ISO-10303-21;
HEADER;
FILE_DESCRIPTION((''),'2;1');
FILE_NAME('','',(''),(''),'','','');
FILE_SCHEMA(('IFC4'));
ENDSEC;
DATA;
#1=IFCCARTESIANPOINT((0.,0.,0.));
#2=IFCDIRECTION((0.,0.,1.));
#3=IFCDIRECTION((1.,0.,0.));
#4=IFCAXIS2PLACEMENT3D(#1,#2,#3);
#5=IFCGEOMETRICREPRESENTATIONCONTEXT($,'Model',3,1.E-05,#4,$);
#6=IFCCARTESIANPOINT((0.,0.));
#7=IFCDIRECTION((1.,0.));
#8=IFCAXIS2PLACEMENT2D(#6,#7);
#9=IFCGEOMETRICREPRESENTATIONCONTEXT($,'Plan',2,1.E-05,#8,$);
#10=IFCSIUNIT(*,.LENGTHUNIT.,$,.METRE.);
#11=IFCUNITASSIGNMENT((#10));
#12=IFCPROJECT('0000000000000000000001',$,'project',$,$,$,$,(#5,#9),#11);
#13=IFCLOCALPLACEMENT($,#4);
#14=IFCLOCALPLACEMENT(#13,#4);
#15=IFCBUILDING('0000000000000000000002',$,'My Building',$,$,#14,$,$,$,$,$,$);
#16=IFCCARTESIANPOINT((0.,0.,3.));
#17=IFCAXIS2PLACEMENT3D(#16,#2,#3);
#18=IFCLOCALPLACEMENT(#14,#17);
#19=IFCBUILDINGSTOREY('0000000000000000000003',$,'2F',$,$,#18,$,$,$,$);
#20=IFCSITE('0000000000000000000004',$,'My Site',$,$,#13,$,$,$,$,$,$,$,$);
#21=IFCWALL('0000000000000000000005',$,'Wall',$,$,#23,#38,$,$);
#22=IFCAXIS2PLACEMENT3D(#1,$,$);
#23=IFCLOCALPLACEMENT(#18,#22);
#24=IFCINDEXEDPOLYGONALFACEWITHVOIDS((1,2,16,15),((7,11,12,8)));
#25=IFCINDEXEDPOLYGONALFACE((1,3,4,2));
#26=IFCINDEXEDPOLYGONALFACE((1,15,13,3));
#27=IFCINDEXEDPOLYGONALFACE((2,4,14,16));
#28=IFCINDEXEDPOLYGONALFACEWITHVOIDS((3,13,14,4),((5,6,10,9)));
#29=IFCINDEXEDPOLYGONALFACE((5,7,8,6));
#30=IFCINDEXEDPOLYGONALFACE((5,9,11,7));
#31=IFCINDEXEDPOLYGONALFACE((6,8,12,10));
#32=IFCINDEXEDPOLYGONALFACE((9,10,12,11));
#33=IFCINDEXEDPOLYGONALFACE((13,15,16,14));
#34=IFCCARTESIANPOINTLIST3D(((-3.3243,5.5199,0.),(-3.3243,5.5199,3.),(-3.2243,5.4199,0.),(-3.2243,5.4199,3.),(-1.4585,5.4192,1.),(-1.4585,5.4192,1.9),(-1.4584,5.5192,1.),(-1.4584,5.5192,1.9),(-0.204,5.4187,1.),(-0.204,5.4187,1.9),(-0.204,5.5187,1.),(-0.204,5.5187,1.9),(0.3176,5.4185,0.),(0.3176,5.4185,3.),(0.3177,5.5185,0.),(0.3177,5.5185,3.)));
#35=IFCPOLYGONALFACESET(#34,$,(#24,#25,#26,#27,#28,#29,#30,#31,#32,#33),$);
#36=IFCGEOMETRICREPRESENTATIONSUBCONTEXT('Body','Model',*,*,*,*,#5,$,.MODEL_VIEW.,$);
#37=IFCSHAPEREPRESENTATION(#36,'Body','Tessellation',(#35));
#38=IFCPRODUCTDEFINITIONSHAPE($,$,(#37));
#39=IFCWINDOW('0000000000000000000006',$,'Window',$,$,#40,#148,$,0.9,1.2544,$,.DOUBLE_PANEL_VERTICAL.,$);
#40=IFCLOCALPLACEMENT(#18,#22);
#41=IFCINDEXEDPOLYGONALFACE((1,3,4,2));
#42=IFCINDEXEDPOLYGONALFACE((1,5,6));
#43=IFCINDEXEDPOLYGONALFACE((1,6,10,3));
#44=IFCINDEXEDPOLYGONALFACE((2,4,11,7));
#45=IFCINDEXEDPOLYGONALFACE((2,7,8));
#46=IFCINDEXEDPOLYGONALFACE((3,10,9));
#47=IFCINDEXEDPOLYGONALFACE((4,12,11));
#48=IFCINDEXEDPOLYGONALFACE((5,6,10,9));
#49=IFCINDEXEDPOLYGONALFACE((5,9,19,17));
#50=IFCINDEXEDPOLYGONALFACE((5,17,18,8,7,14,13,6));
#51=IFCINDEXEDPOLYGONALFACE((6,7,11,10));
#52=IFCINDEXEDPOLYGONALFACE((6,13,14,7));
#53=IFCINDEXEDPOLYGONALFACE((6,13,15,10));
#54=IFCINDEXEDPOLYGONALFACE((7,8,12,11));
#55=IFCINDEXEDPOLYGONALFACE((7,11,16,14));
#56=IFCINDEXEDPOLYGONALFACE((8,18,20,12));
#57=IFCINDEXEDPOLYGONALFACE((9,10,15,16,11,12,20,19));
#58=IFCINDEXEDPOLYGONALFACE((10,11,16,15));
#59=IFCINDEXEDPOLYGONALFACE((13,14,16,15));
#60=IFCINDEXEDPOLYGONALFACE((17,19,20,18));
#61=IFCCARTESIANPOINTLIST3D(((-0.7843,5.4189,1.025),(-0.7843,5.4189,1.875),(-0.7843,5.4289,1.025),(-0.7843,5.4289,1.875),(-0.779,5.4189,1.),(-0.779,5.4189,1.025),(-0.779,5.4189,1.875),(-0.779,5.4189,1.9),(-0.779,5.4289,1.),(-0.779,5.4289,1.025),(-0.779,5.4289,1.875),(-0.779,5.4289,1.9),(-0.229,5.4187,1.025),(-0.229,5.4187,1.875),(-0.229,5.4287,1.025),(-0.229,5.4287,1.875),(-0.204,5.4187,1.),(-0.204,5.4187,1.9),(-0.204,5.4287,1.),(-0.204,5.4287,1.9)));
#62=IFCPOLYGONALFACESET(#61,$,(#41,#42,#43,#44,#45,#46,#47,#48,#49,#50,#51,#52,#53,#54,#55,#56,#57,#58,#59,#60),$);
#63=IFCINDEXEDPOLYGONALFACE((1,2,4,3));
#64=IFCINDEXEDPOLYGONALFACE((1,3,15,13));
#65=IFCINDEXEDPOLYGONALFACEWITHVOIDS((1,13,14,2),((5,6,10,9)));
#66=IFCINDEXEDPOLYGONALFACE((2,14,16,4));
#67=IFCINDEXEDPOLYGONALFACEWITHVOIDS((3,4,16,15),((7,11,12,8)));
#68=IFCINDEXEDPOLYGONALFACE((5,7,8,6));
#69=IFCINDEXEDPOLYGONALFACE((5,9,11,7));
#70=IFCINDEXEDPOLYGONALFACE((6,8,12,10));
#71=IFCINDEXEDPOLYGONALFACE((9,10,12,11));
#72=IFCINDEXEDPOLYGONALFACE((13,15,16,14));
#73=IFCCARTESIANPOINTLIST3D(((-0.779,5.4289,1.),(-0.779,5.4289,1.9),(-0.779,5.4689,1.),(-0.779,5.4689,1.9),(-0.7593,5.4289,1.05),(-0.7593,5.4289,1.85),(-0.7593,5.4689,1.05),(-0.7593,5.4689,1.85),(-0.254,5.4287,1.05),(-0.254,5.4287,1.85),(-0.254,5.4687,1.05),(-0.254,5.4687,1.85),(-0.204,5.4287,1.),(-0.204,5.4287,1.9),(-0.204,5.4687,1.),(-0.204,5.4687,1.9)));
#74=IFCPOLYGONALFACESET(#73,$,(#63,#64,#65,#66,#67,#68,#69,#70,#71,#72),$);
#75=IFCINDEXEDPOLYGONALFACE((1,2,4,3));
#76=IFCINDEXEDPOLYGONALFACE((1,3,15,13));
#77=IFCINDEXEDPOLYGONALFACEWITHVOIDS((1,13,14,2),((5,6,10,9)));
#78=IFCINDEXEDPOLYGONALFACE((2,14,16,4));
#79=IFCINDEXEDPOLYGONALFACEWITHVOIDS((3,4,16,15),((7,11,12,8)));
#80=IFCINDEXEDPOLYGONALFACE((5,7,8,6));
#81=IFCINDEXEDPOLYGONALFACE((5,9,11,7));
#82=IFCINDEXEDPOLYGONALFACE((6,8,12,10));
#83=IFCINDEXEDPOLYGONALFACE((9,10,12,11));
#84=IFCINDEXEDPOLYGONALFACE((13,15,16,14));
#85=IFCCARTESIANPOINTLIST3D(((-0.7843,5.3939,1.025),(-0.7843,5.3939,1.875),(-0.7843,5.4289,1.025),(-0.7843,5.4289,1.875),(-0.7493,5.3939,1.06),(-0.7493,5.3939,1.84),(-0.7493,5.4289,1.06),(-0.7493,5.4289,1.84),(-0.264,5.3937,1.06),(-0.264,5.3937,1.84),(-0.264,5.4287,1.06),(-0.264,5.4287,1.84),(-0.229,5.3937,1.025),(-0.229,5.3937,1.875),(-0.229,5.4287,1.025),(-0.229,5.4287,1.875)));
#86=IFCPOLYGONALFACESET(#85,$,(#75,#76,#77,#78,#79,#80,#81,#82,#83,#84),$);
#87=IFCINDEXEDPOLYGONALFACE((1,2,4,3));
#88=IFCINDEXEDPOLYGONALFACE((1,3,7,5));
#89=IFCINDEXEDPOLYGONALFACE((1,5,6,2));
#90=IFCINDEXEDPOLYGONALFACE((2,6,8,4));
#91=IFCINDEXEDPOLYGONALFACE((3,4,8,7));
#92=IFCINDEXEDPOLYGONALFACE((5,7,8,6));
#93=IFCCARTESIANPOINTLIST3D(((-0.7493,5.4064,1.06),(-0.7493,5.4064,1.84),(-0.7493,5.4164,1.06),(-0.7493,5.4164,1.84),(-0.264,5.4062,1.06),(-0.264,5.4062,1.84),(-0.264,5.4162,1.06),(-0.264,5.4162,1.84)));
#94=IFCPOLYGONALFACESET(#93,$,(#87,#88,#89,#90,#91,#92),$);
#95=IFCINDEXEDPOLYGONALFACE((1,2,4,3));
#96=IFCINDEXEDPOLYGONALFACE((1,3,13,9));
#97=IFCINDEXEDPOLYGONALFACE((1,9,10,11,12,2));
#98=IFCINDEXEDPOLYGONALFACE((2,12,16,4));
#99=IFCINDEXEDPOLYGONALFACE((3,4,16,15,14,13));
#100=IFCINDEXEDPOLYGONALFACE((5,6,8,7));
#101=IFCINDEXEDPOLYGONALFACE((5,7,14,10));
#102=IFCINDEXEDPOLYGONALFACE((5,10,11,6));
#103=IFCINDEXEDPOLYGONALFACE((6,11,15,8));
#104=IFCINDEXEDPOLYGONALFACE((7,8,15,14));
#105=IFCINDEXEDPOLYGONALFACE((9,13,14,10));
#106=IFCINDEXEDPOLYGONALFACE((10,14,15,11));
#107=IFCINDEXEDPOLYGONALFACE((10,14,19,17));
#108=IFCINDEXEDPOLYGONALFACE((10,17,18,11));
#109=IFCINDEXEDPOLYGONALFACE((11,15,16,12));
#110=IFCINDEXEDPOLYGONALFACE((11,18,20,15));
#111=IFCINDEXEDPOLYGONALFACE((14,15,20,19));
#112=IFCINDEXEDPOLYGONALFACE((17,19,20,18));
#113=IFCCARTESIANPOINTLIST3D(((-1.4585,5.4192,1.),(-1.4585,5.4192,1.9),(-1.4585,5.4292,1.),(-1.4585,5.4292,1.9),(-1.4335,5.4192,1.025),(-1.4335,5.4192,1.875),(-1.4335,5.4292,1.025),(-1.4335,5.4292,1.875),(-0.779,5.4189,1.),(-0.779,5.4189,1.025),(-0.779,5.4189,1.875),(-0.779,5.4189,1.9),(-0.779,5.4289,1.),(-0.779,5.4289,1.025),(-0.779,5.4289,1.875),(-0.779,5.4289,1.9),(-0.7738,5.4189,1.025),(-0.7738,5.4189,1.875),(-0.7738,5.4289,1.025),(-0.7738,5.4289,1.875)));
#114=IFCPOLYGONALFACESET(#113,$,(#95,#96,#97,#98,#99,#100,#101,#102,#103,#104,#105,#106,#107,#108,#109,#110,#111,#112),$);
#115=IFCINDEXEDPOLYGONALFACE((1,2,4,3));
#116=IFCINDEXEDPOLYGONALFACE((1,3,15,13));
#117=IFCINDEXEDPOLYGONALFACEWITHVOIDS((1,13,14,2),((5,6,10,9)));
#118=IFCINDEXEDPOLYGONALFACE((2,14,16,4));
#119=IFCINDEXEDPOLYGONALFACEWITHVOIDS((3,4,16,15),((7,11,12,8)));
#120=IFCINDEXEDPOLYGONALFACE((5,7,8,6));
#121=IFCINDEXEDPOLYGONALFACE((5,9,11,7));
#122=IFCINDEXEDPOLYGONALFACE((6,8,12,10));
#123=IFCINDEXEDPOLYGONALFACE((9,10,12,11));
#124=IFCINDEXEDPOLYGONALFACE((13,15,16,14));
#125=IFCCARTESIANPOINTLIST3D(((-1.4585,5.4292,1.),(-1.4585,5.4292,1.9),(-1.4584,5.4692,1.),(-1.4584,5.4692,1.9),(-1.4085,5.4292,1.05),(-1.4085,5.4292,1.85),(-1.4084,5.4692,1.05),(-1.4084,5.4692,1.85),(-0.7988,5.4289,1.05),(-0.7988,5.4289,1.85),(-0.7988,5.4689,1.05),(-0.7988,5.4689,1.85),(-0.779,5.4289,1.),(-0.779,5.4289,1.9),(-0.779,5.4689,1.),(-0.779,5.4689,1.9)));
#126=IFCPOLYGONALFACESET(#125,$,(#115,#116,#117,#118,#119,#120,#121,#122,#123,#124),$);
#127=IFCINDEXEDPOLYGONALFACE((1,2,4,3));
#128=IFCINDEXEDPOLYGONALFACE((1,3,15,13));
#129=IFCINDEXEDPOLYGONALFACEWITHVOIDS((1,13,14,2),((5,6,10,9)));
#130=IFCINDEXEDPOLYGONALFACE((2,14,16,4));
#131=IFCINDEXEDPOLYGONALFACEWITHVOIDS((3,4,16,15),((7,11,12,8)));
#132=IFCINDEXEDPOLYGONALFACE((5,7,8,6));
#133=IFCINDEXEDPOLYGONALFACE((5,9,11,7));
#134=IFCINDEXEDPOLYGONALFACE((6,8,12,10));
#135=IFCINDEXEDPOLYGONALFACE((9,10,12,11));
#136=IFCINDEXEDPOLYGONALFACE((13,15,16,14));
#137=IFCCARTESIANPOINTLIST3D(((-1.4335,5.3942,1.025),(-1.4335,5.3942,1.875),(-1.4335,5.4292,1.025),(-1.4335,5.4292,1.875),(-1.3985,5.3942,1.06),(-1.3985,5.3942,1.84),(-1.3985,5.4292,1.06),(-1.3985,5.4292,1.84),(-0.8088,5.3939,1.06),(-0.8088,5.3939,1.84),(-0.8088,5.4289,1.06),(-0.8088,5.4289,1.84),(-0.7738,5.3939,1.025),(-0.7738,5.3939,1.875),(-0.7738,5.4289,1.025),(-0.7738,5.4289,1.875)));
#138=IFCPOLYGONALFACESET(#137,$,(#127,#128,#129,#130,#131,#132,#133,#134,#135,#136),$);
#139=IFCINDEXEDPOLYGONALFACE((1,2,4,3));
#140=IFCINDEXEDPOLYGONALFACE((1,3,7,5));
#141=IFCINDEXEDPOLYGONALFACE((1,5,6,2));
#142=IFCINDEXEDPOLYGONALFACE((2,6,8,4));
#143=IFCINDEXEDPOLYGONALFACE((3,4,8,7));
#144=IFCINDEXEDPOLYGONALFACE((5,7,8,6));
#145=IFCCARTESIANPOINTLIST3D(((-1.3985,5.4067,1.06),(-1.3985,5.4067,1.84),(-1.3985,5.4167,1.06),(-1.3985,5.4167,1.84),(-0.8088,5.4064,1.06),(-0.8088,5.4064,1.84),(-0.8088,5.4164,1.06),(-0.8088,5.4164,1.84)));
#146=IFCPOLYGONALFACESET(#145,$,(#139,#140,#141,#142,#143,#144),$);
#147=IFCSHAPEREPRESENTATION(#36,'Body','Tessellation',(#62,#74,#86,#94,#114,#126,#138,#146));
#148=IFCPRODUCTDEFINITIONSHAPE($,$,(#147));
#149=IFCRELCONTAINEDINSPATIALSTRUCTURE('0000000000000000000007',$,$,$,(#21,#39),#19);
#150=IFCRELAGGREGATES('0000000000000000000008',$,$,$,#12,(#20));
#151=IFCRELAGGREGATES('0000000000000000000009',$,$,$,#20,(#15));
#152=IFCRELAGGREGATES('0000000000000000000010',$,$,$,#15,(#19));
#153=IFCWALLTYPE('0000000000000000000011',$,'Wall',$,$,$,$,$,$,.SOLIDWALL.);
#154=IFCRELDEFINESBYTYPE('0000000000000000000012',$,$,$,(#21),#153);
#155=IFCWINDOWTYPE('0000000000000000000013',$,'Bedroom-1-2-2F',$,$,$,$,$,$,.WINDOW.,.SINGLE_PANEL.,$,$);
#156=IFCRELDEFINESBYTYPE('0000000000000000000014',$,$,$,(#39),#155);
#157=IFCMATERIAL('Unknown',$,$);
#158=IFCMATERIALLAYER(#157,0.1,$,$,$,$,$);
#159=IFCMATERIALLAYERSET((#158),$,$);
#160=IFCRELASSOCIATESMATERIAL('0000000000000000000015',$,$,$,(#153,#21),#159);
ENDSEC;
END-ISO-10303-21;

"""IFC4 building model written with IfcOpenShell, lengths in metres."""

from ifc_helpers import new_model, entity, si_unit, frame, origin_with_axes, origin_2d_with_axis, place, context, subcontext, project, spatial, line, indexed_curve, outline, extrude, shape, source, transform, mapped, material, layer, layer_set, layer_usage, type_object, type_shapes, element, fill, save


model = new_model("IFC4")

# Units and contexts
model_context = context("Model", 3, precision=1e-05, world=origin_with_axes())
plan_context = context("Plan", 2, precision=1e-05, world=origin_2d_with_axis())
body_context_1 = subcontext(model_context, "Body", "Model", "MODEL_VIEW")
body_context_2 = subcontext(plan_context, "Body", "Plan", "PLAN_VIEW")
ifc_project = project(units=[si_unit("LENGTHUNIT", "METRE")], contexts=[model_context, plan_context])

# Site, building, storey
site_placement = place(None, origin_with_axes())
site = spatial("IfcSite", under=ifc_project, at=site_placement, Name="My Site")
building_placement = place(site_placement, origin_with_axes())
building = spatial("IfcBuilding", under=site, at=building_placement, Name="My Building")
storey_placement = place(building_placement, frame((0.0, 0.0, 3.0), z_axis=(0.0, 0.0, 1.0), x_axis=(1.0, 0.0, 0.0)))
storey = spatial("IfcBuildingStorey", under=building, at=storey_placement, Name="2F")

# Shared definitions
ifc_material = material(Name="Unknown")

# Shared definitions
ifc_layer = layer(ifc_material, 0.1)
ifc_layer_set = layer_set([ifc_layer])
wall_type = type_object("IfcWallType", Name="Wall", PredefinedType="SOLIDWALL", material=ifc_layer_set)

# Wall, opening, window
ifc_layer_usage_1 = layer_usage(ifc_layer_set, "AXIS2", "POSITIVE", 0.0)
wall_1_placement = place(storey_placement, frame((-3.3243, 5.4199, 0.0), z_axis=(0.0, 0.0, 1.0), x_axis=(1.0, -0.000383, 0.0)))
wall_1 = element("IfcWall", 1, at=wall_1_placement, inside=storey, type_object=wall_type, material=ifc_layer_usage_1, Name="Wall", context=body_context_1, shape_type="SweptSolid", body=[
    extrude(outline(indexed_curve([(0.1, 0.0), (0.0, 0.1), (3.6419, 0.1), (3.6419, 0.0)], segments=[line(1, 2, 3, 4, 1)])), origin_with_axes(), (0.0, 0.0, 1.0), 3.0),
])
shared_shape_1 = source(origin_with_axes(), body_context_1, "Body", "SweptSolid", [
    extrude(outline(indexed_curve([(0.0, 0.0), (1.2544, 0.0), (1.2544, 0.9), (0.0, 0.9)], segments=[line(1, 2, 3, 4, 1)])), frame((0.0, -0.6, 0.0), z_axis=(0.0, -1.0, 0.0), x_axis=(1.0, 0.0, 0.0)), (0.0, 0.0, -1.0), 1.2),
])
opening_1_placement = place(wall_1_placement, frame((3.1202, 0.1, 1.0), z_axis=(0.0, 0.0, 1.0), x_axis=(-1.0, 0.0, 0.0)))
opening_1 = element("IfcOpeningElement", 2, at=opening_1_placement, cuts=wall_1, PredefinedType="OPENING", context=body_context_1, shape_type="MappedRepresentation", body=[
    mapped(shared_shape_1, transform((0.0, 0.0, 0.0), x_axis=(1.0, 0.0, 0.0), y_axis=(0.0, 1.0, 0.0), z_axis=(0.0, 0.0, 1.0), scale=1.0)),
])
window_type_1 = type_object("IfcWindowType", Name="Bedroom-1-2-2F", PartitioningType="SINGLE_PANEL", PredefinedType="WINDOW")
shared_shape_2 = source(origin_with_axes(), body_context_1, "Body", "SweptSolid", [
    extrude(outline(indexed_curve([(0.0, 0.0), (0.575, 0.0), (0.575, 0.9), (0.0, 0.9)], segments=[line(1, 2, 3, 4, 1)]), holes=[indexed_curve([(0.025, 0.025), (0.5803, 0.025), (0.5803, 0.875), (0.025, 0.875)], segments=[line(1, 2, 3, 4, 1)])]), frame((0.0, 0.09, 0.0), z_axis=(0.0, -1.0, 0.0), x_axis=(1.0, 0.0, 0.0)), (0.0, 0.0, -1.0), 0.01),
    extrude(outline(indexed_curve([(0.0, 0.0), (0.575, 0.0), (0.575, 0.9), (0.0, 0.9)], segments=[line(1, 2, 3, 4, 1)]), holes=[indexed_curve([(0.05, 0.05), (0.5553, 0.05), (0.5553, 0.85), (0.05, 0.85)], segments=[line(1, 2, 3, 4, 1)])]), frame((0.0, 0.05, 0.0), z_axis=(0.0, -1.0, 0.0), x_axis=(1.0, 0.0, 0.0)), (0.0, 0.0, -1.0), 0.04),
    extrude(outline(indexed_curve([(0.0, 0.0), (0.5553, 0.0), (0.5553, 0.85), (0.0, 0.85)], segments=[line(1, 2, 3, 4, 1)]), holes=[indexed_curve([(0.035, 0.035), (0.5203, 0.035), (0.5203, 0.815), (0.035, 0.815)], segments=[line(1, 2, 3, 4, 1)])]), frame((0.025, 0.09, 0.025), z_axis=(0.0, -1.0, 0.0), x_axis=(1.0, 0.0, 0.0)), (0.0, 0.0, -1.0), 0.035),
    extrude(outline(indexed_curve([(0.035, 0.035), (0.5203, 0.035), (0.5203, 0.815), (0.035, 0.815)], segments=[line(1, 2, 3, 4, 1)])), frame((0.025, 0.1025, 0.025), z_axis=(0.0, -1.0, 0.0), x_axis=(1.0, 0.0, 0.0)), (0.0, 0.0, -1.0), 0.01),
    extrude(outline(indexed_curve([(0.0, 0.0), (0.6794, 0.0), (0.6794, 0.9), (0.0, 0.9)], segments=[line(1, 2, 3, 4, 1)]), holes=[indexed_curve([(-0.0052, 0.025), (0.6544, 0.025), (0.6544, 0.875), (-0.0052, 0.875)], segments=[line(1, 2, 3, 4, 1)])]), frame((0.575, 0.09, 0.0), z_axis=(0.0, -1.0, 0.0), x_axis=(1.0, 0.0, 0.0)), (0.0, 0.0, -1.0), 0.01),
    extrude(outline(indexed_curve([(0.0, 0.0), (0.6794, 0.0), (0.6794, 0.9), (0.0, 0.9)], segments=[line(1, 2, 3, 4, 1)]), holes=[indexed_curve([(0.0198, 0.05), (0.6294, 0.05), (0.6294, 0.85), (0.0198, 0.85)], segments=[line(1, 2, 3, 4, 1)])]), frame((0.575, 0.05, 0.0), z_axis=(0.0, -1.0, 0.0), x_axis=(1.0, 0.0, 0.0)), (0.0, 0.0, -1.0), 0.04),
    extrude(outline(indexed_curve([(0.0, 0.0), (0.6596, 0.0), (0.6596, 0.85), (0.0, 0.85)], segments=[line(1, 2, 3, 4, 1)]), holes=[indexed_curve([(0.035, 0.035), (0.6246, 0.035), (0.6246, 0.815), (0.035, 0.815)], segments=[line(1, 2, 3, 4, 1)])]), frame((0.5698, 0.09, 0.025), z_axis=(0.0, -1.0, 0.0), x_axis=(1.0, 0.0, 0.0)), (0.0, 0.0, -1.0), 0.035),
    extrude(outline(indexed_curve([(0.035, 0.035), (0.6246, 0.035), (0.6246, 0.815), (0.035, 0.815)], segments=[line(1, 2, 3, 4, 1)])), frame((0.5698, 0.1025, 0.025), z_axis=(0.0, -1.0, 0.0), x_axis=(1.0, 0.0, 0.0)), (0.0, 0.0, -1.0), 0.01),
])
shared_shape_3 = source(origin_with_axes(), body_context_2, "Body", "Curve2D", [
    entity("IfcIndexedPolyCurve", entity("IfcCartesianPointList2D", [[0.05, 0.05], [0.5553, 0.05]])),
    entity("IfcIndexedPolyCurve", entity("IfcCartesianPointList2D", [[0.0, 0.1], [0.025, 0.1], [0.025, 0.09], [0.05, 0.09], [0.05, 0.05], [0.0, 0.05]]), [entity("IfcLineIndex", [1, 2, 3, 4, 5, 6, 1])]),
    entity("IfcIndexedPolyCurve", entity("IfcCartesianPointList2D", [[0.575, 0.1], [0.5803, 0.1], [0.5803, 0.09], [0.5553, 0.09], [0.5553, 0.05], [0.575, 0.05]])),
    entity("IfcIndexedPolyCurve", entity("IfcCartesianPointList2D", [[0.025, 0.09], [0.06, 0.09], [0.06, 0.125], [0.025, 0.125]]), [entity("IfcLineIndex", [1, 2, 3, 4, 1])]),
    entity("IfcIndexedPolyCurve", entity("IfcCartesianPointList2D", [[0.5803, 0.09], [0.5453, 0.09], [0.5453, 0.125], [0.5803, 0.125]]), [entity("IfcLineIndex", [1, 2, 3, 4, 1])]),
    entity("IfcIndexedPolyCurve", entity("IfcCartesianPointList2D", [[0.06, 0.09], [0.5453, 0.09]])),
    entity("IfcIndexedPolyCurve", entity("IfcCartesianPointList2D", [[0.06, 0.125], [0.5453, 0.125]])),
    entity("IfcIndexedPolyCurve", entity("IfcCartesianPointList2D", [[0.06, 0.1075], [0.5453, 0.1075]])),
    entity("IfcIndexedPolyCurve", entity("IfcCartesianPointList2D", [[0.5948, 0.05], [1.2044, 0.05]])),
    entity("IfcIndexedPolyCurve", entity("IfcCartesianPointList2D", [[0.575, 0.1], [0.5698, 0.1], [0.5698, 0.09], [0.5948, 0.09], [0.5948, 0.05], [0.575, 0.05]])),
    entity("IfcIndexedPolyCurve", entity("IfcCartesianPointList2D", [[1.2544, 0.1], [1.2294, 0.1], [1.2294, 0.09], [1.2044, 0.09], [1.2044, 0.05], [1.2544, 0.05]]), [entity("IfcLineIndex", [1, 2, 3, 4, 5, 6, 1])]),
    entity("IfcIndexedPolyCurve", entity("IfcCartesianPointList2D", [[0.5698, 0.09], [0.6048, 0.09], [0.6048, 0.125], [0.5698, 0.125]]), [entity("IfcLineIndex", [1, 2, 3, 4, 1])]),
    entity("IfcIndexedPolyCurve", entity("IfcCartesianPointList2D", [[1.2294, 0.09], [1.1944, 0.09], [1.1944, 0.125], [1.2294, 0.125]]), [entity("IfcLineIndex", [1, 2, 3, 4, 1])]),
    entity("IfcIndexedPolyCurve", entity("IfcCartesianPointList2D", [[0.6048, 0.09], [1.1944, 0.09]])),
    entity("IfcIndexedPolyCurve", entity("IfcCartesianPointList2D", [[0.6048, 0.125], [1.1944, 0.125]])),
    entity("IfcIndexedPolyCurve", entity("IfcCartesianPointList2D", [[0.6048, 0.1075], [1.1944, 0.1075]])),
])
type_shapes(window_type_1, [shared_shape_2, shared_shape_3])
window_1_placement = place(opening_1_placement, origin_with_axes())
window_1 = element("IfcWindow", 3, at=window_1_placement, inside=storey, type_object=window_type_1, Name="Window", OverallHeight=0.9, OverallWidth=1.2544, PartitioningType="DOUBLE_PANEL_VERTICAL", shapes=[
    shape(body_context_1, "Body", "MappedRepresentation", [mapped(shared_shape_2, transform((0.0, 0.0, 0.0), x_axis=(1.0, 0.0, 0.0), y_axis=(0.0, 1.0, 0.0), z_axis=(0.0, 0.0, 1.0), scale=1.0))]),
    shape(body_context_2, "Body", "MappedRepresentation", [mapped(shared_shape_3, transform((0.0, 0.0, 0.0), x_axis=(1.0, 0.0, 0.0), y_axis=(0.0, 1.0, 0.0), z_axis=(0.0, 0.0, 1.0), scale=1.0))]),
])
fill(opening_1, window_1)

save(model, "model.ifc")
